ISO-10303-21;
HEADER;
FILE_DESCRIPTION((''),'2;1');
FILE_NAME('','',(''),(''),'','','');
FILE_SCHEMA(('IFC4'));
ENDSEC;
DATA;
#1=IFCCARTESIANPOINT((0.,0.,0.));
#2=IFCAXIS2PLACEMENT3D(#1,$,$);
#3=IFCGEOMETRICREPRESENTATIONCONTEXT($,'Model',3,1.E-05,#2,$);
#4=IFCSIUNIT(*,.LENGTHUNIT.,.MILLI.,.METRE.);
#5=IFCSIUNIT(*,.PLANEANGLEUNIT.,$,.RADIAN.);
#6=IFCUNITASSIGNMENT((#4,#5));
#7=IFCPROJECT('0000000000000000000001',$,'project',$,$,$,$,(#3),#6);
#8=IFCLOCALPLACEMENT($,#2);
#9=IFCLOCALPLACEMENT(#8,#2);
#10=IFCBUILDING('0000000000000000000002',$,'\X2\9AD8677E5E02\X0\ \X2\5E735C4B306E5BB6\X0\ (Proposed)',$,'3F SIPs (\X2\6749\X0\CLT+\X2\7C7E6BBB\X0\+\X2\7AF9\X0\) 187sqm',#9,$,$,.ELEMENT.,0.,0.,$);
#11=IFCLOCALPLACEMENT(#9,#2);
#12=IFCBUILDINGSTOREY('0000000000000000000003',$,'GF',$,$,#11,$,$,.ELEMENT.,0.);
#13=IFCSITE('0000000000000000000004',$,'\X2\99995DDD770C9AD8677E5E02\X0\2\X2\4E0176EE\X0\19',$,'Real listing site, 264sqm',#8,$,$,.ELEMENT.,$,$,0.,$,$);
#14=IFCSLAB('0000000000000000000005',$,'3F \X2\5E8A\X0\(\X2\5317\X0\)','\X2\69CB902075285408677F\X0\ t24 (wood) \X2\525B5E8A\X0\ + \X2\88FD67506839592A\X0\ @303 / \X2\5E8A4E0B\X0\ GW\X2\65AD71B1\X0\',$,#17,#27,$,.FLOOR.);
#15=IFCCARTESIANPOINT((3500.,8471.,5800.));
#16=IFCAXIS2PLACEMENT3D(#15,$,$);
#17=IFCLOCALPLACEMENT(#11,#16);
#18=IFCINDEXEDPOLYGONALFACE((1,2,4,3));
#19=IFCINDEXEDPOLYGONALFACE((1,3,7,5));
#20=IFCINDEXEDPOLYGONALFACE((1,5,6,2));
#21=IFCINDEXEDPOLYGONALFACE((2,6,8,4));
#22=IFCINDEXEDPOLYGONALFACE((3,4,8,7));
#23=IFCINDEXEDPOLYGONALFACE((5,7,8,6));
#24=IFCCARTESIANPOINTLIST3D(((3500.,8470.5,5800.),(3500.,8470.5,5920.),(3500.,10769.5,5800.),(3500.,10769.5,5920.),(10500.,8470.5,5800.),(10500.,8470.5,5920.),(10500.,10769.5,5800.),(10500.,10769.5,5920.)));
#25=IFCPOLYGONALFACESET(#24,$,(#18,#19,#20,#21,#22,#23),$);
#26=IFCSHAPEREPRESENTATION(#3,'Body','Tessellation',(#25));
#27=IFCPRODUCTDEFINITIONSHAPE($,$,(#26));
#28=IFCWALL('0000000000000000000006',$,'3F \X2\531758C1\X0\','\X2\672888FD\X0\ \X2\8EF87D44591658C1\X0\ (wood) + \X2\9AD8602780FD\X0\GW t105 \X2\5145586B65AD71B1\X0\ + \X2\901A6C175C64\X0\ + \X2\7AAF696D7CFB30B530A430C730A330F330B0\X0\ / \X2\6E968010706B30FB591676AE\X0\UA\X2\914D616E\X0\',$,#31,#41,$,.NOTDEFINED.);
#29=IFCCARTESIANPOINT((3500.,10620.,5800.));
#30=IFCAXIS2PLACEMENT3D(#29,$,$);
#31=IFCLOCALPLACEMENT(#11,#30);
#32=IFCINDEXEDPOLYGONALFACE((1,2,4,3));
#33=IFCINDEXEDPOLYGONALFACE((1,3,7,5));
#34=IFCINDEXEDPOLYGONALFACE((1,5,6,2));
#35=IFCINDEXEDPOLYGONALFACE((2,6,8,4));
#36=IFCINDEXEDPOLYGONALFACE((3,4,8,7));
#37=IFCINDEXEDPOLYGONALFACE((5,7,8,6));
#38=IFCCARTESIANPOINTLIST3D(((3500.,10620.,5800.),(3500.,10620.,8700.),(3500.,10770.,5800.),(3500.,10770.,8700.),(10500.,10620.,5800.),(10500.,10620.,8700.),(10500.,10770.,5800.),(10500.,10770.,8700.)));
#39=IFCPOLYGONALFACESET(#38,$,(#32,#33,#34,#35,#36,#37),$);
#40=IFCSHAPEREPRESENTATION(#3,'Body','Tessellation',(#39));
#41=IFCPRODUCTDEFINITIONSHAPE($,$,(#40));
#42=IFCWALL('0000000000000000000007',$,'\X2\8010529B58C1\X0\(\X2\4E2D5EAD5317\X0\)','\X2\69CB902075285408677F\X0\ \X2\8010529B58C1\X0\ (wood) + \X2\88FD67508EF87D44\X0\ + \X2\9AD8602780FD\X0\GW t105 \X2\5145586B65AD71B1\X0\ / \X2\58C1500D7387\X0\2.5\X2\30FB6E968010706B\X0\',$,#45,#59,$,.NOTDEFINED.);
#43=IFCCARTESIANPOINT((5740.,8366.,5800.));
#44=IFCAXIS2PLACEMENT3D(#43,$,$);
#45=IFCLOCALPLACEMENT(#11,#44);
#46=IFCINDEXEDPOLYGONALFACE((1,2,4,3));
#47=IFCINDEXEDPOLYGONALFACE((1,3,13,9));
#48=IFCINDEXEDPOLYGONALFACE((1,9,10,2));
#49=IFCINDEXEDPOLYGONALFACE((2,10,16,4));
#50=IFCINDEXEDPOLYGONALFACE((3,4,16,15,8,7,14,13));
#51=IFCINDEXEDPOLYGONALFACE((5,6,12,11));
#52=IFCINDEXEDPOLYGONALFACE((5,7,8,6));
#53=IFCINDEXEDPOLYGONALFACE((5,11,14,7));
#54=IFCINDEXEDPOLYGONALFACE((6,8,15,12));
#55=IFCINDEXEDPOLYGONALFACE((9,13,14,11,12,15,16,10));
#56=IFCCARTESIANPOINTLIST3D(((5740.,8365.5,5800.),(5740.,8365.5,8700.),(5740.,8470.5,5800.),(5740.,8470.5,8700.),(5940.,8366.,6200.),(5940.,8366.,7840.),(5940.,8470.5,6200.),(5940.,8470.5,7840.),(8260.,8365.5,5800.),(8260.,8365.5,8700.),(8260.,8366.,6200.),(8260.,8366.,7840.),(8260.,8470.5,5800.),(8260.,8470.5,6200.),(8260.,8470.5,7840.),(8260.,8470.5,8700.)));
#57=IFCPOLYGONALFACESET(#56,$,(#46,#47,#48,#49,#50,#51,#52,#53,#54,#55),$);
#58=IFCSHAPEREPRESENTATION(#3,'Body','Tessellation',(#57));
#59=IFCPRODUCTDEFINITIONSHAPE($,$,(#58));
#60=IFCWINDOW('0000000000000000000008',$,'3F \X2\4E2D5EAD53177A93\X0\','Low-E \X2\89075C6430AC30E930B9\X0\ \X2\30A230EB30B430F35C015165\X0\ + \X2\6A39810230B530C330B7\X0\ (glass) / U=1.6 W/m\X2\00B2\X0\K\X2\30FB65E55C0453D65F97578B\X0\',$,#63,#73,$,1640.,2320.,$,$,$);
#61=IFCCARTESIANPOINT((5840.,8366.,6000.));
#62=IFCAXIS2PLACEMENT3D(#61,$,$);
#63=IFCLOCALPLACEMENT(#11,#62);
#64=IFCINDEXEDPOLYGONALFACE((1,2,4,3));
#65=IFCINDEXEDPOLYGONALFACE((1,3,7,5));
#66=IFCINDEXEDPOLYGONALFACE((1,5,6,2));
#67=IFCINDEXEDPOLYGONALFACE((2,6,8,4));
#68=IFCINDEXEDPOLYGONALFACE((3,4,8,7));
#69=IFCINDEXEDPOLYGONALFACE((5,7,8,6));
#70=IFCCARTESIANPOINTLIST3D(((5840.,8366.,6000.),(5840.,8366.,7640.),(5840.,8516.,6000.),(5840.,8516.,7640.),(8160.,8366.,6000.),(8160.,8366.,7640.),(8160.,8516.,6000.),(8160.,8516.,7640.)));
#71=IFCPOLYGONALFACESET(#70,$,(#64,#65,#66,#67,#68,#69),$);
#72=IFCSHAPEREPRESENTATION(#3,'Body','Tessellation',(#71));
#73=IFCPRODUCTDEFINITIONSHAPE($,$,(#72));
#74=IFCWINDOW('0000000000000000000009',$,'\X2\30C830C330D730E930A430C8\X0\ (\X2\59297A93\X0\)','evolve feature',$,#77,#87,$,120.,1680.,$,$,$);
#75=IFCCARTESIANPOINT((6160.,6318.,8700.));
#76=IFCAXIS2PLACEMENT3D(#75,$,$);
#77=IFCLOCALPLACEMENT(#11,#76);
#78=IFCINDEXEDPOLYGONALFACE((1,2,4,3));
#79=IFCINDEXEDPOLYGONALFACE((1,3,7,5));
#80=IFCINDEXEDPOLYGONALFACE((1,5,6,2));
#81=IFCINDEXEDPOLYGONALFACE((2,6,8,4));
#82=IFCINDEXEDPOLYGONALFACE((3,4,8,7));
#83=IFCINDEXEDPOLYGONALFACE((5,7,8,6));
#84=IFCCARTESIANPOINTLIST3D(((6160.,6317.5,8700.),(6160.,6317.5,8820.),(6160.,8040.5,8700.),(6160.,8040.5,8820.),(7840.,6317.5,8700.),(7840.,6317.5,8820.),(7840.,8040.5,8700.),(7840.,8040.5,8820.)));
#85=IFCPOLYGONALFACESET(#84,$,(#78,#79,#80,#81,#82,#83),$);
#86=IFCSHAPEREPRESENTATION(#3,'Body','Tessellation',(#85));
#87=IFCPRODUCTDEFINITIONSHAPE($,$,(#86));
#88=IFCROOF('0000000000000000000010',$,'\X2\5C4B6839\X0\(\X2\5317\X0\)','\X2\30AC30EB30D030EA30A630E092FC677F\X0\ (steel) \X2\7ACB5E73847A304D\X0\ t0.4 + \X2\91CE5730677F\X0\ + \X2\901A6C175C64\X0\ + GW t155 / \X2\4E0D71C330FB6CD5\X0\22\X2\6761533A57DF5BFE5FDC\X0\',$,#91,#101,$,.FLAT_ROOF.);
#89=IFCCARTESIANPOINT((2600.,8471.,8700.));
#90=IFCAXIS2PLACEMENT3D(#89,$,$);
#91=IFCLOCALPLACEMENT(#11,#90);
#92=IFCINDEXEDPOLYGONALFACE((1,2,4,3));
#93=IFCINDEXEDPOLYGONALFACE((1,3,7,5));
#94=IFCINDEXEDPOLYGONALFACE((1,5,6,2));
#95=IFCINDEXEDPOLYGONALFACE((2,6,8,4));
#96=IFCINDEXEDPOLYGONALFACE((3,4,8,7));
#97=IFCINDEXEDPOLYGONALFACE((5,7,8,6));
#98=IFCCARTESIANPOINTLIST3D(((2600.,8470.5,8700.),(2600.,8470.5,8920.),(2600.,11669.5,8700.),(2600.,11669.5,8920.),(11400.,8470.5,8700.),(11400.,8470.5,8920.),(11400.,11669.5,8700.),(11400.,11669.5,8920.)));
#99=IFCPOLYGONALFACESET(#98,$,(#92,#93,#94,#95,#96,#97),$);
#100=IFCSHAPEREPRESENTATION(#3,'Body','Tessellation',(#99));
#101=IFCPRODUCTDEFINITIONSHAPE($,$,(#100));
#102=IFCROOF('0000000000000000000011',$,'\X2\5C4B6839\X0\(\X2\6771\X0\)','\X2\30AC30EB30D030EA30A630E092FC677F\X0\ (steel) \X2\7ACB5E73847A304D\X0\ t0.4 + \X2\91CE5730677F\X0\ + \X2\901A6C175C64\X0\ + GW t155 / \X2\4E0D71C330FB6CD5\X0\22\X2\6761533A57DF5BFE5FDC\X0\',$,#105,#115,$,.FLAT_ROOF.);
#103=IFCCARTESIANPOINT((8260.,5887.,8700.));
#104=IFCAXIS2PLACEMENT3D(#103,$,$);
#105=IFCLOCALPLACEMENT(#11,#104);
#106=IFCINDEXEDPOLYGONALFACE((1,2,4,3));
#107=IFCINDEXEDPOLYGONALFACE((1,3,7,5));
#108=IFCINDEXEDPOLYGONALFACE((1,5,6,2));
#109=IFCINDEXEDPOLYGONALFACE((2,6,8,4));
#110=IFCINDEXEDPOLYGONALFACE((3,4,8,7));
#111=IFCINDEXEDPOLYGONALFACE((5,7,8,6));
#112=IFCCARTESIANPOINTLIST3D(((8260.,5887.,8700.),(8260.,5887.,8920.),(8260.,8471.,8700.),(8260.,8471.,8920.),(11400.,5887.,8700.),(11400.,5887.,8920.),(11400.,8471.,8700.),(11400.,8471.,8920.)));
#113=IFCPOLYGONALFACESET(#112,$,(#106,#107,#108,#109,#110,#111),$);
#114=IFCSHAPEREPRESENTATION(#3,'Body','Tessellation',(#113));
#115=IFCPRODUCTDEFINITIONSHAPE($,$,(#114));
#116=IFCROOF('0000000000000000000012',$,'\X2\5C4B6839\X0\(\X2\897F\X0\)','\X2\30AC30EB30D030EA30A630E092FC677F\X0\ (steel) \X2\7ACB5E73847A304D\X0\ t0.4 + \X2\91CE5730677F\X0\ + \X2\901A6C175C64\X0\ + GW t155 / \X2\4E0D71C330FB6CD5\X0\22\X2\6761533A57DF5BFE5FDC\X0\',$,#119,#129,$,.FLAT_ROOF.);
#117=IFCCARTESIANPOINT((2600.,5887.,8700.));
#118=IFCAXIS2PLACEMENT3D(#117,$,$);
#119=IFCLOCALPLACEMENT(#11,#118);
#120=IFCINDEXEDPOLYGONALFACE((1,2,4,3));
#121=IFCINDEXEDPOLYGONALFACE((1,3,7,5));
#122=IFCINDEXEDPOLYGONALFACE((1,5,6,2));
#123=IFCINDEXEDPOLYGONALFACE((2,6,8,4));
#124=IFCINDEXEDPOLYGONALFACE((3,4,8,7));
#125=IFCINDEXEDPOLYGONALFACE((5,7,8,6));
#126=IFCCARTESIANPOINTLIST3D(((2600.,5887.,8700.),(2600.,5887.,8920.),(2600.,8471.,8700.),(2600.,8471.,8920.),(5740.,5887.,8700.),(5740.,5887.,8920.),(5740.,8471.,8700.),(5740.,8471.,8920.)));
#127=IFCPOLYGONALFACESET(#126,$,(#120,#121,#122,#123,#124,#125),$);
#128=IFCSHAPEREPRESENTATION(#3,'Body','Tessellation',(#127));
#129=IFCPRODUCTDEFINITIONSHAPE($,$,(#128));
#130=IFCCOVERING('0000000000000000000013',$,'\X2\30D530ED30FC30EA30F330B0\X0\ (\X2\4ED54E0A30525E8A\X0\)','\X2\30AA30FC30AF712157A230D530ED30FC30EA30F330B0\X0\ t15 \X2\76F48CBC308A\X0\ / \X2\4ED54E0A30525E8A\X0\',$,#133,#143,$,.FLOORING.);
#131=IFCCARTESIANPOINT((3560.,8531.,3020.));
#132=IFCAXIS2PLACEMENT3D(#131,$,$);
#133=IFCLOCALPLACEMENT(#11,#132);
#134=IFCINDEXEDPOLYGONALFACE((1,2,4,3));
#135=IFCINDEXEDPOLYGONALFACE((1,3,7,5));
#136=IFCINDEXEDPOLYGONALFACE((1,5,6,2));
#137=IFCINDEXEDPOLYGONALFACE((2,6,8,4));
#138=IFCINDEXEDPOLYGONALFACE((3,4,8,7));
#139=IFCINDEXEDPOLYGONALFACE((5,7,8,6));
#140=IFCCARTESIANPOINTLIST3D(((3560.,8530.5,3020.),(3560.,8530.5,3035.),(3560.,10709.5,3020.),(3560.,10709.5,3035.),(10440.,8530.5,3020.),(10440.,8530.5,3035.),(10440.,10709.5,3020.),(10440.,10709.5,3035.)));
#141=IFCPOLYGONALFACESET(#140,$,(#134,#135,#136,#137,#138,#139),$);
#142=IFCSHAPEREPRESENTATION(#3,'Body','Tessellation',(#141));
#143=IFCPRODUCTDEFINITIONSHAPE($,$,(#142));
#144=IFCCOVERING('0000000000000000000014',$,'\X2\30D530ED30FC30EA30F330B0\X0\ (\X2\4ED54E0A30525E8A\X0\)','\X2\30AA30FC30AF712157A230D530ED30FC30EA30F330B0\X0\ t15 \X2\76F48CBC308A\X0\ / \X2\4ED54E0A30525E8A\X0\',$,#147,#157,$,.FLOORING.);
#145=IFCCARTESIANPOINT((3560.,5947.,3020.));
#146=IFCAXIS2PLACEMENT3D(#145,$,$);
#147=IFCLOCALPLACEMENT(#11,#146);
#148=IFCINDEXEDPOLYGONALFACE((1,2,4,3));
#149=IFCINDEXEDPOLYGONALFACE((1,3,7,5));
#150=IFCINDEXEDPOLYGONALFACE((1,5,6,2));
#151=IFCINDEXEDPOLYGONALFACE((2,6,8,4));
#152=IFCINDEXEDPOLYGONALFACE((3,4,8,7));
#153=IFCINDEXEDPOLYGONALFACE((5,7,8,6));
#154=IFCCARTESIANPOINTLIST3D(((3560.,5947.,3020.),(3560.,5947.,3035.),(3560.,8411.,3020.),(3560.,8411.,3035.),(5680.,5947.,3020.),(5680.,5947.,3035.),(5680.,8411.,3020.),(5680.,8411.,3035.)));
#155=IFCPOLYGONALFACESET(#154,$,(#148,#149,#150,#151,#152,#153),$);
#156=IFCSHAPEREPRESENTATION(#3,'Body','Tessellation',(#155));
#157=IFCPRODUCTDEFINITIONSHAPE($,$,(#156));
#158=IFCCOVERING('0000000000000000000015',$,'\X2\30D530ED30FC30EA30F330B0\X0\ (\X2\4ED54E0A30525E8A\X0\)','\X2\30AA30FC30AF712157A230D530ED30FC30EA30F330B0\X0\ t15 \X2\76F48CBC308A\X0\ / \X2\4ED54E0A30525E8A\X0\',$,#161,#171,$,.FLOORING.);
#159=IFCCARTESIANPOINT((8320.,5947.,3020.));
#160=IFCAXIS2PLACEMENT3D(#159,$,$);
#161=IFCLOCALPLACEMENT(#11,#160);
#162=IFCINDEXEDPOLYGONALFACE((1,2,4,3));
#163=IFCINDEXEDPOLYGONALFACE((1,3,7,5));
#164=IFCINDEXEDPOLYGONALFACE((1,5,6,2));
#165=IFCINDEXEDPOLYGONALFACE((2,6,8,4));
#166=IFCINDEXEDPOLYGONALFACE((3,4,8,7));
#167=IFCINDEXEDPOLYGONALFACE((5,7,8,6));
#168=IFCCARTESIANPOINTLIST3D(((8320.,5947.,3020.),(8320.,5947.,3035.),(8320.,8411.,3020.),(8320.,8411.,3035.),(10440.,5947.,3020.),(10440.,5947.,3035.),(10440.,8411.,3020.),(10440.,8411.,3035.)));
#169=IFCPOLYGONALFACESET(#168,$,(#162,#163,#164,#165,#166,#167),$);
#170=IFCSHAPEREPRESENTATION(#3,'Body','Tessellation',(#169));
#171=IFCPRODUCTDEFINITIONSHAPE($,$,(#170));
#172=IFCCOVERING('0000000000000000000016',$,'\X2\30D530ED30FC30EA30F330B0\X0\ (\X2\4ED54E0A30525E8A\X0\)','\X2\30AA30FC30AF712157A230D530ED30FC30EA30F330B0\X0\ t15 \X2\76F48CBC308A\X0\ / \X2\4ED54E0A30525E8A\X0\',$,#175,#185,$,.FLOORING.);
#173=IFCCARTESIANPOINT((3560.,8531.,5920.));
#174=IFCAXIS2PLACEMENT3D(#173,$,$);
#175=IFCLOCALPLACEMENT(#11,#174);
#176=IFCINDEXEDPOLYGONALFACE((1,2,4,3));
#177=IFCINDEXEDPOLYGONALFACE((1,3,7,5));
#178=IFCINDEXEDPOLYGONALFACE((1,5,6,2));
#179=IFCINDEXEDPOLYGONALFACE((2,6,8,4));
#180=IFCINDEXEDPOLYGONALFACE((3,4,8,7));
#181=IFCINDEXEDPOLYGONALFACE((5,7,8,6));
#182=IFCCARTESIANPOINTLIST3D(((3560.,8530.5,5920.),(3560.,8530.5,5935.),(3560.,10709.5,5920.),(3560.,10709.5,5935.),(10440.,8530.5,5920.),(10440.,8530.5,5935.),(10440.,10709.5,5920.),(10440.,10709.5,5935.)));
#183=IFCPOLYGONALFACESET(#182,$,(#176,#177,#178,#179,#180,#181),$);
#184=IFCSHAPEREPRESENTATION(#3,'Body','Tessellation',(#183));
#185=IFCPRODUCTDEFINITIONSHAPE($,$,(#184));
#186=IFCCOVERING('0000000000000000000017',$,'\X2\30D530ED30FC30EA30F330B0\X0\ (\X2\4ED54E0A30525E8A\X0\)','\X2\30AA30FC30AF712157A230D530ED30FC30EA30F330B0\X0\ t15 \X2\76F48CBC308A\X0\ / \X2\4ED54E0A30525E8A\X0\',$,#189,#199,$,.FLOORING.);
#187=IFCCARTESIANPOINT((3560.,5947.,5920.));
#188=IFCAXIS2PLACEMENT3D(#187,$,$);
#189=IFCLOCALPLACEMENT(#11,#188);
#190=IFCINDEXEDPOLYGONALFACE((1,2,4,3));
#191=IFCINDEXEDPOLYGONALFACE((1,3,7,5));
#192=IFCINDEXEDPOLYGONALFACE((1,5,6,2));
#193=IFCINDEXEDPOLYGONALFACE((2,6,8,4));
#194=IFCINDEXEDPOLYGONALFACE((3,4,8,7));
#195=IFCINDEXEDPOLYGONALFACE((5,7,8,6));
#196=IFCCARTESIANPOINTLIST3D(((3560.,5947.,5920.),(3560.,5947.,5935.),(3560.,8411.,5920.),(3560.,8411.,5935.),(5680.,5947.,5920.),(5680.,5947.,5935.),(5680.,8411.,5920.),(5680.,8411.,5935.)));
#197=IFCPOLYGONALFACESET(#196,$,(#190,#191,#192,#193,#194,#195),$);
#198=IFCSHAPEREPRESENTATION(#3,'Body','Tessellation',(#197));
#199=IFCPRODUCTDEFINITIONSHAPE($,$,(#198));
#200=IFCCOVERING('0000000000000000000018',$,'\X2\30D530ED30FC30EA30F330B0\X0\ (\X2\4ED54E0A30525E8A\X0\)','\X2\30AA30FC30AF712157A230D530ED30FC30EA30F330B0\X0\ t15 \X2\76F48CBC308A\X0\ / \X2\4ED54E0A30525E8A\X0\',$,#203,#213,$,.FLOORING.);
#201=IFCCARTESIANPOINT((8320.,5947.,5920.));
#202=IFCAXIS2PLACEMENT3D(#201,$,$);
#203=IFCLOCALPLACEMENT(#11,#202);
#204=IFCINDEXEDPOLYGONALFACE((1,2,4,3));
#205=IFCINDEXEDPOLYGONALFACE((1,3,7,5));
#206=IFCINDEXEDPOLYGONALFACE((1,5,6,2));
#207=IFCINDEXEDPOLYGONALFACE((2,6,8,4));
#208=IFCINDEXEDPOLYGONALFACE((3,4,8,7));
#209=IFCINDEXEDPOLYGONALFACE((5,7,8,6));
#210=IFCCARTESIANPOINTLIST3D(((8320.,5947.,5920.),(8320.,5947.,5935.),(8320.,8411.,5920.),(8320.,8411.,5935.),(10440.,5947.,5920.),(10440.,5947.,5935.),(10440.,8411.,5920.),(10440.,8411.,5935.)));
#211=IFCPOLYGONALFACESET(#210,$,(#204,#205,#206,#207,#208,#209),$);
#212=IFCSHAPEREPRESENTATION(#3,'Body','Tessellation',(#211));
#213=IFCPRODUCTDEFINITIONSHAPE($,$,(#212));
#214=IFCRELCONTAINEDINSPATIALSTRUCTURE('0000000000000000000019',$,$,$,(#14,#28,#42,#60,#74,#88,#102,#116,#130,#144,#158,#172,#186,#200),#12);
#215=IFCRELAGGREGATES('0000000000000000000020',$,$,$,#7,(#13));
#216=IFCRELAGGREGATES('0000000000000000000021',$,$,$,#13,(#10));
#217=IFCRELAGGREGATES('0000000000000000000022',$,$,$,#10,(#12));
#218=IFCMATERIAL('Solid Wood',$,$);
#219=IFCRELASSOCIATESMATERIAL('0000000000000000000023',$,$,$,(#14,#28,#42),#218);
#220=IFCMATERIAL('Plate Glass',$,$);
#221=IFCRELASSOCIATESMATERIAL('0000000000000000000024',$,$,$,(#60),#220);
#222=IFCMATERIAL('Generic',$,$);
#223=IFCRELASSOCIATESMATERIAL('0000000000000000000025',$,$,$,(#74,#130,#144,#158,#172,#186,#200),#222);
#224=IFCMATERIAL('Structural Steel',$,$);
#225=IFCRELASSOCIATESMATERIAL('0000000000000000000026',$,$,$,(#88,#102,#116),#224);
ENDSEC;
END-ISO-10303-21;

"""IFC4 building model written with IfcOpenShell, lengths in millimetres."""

from ifc_helpers import new_model, si_unit, frame, frame_2d, origin, place, context, project, spatial, rectangle, extrude, material, element, fill, save


model = new_model("IFC4")

# Units and contexts
model_context = context("Model", 3, precision=1e-05, world=origin())
ifc_project = project(units=[si_unit("LENGTHUNIT", "METRE", prefix="MILLI"), si_unit("PLANEANGLEUNIT", "RADIAN")], contexts=[model_context])

# Site, building, storey
site_placement = place(None, origin())
site = spatial("IfcSite", under=ifc_project, at=site_placement, Name="香川県高松市2丁目19", ObjectType="Real listing site, 264sqm", CompositionType="ELEMENT", RefElevation=0.0)
building_placement = place(site_placement, origin())
building = spatial("IfcBuilding", under=site, at=building_placement, Name="高松市 平屋の家 (Proposed)", ObjectType="3F SIPs (杉CLT+籾殻+竹) 187sqm", CompositionType="ELEMENT", ElevationOfRefHeight=0.0, ElevationOfTerrain=0.0)
storey_placement = place(building_placement, origin())
storey = spatial("IfcBuildingStorey", under=building, at=storey_placement, Name="GF", CompositionType="ELEMENT", Elevation=0.0)

# Slab
ifc_material_1 = material(Name="Solid Wood")
slab_placement = place(storey_placement, frame((3500.0, 8471.0, 5800.0)))
element("IfcSlab", 1, at=slab_placement, inside=storey, material=ifc_material_1, Name="3F 床(北)", Description="構造用合板 t24 (wood) 剛床 + 製材根太 @303 / 床下 GW断熱", PredefinedType="FLOOR", context=model_context, shape_type="SweptSolid", body=[
    extrude(rectangle(XDim=7000.0, YDim=2299.0, at=frame_2d((3500.0, 1149.0))), frame((3500.0, 8471.0, 5800.0)), (0.0, 0.0, 1.0), 120.0),
])

# Wall
wall_1_placement = place(storey_placement, frame((3500.0, 10620.0, 5800.0)))
element("IfcWall", 2, at=wall_1_placement, inside=storey, material=ifc_material_1, Name="3F 北壁", Description="木製 軸組外壁 (wood) + 高性能GW t105 充填断熱 + 通気層 + 窯業系サイディング / 準耐火・外皮UA配慮", PredefinedType="NOTDEFINED", context=model_context, shape_type="SweptSolid", body=[
    extrude(rectangle(XDim=7000.0, YDim=150.0, at=frame_2d((3500.0, 75.0))), frame((3500.0, 10620.0, 5800.0)), (0.0, 0.0, 1.0), 2900.0),
])

# Wall, opening, window
wall_2_placement = place(storey_placement, frame((5740.0, 8366.0, 5800.0)))
wall_2 = element("IfcWall", 3, at=wall_2_placement, inside=storey, material=ifc_material_1, Name="耐力壁(中庭北)", Description="構造用合板 耐力壁 (wood) + 製材軸組 + 高性能GW t105 充填断熱 / 壁倍率2.5・準耐火", PredefinedType="NOTDEFINED", context=model_context, shape_type="SweptSolid", body=[
    extrude(rectangle(XDim=2520.0, YDim=105.0, at=frame_2d((1260.0, 52.0))), frame((5740.0, 8366.0, 5800.0)), (0.0, 0.0, 1.0), 2900.0),
])
opening_placement = place(storey_placement, frame((5840.0, 8366.0, 6000.0)))
opening = element("IfcOpeningElement", 4, at=opening_placement, cuts=wall_2, PredefinedType="NOTDEFINED", context=model_context, shape_type="SweptSolid", body=[
    extrude(rectangle(XDim=2320.0, YDim=150.0, at=frame_2d((1160.0, 75.0))), frame((5840.0, 8366.0, 6000.0)), (0.0, 0.0, 1.0), 1640.0),
])
ifc_material_2 = material(Name="Plate Glass")
window_1_placement = place(storey_placement, frame((5840.0, 8366.0, 6000.0)))
window_1 = element("IfcWindow", 5, at=window_1_placement, inside=storey, material=ifc_material_2, Name="3F 中庭北窓", Description="Low-E 複層ガラス アルゴン封入 + 樹脂サッシ (glass) / U=1.6 W/m²K・日射取得型", OverallHeight=1640.0, OverallWidth=2320.0, context=model_context, shape_type="SweptSolid", body=[
    extrude(rectangle(XDim=2320.0, YDim=150.0, at=frame_2d((1160.0, 75.0))), frame((5840.0, 8366.0, 6000.0)), (0.0, 0.0, 1.0), 1640.0),
])
fill(opening, window_1)

# Window
ifc_material_3 = material(Name="Generic")
window_2_placement = place(storey_placement, frame((6160.0, 6318.0, 8700.0)))
element("IfcWindow", 6, at=window_2_placement, inside=storey, material=ifc_material_3, Name="トップライト (天窓)", Description="evolve feature", OverallHeight=120.0, OverallWidth=1680.0, context=model_context, shape_type="SweptSolid", body=[
    extrude(rectangle(XDim=1680.0, YDim=1723.0, at=frame_2d((840.0, 861.0))), frame((6160.0, 6318.0, 8700.0)), (0.0, 0.0, 1.0), 120.0),
])

# Roofs
ifc_material_4 = material(Name="Structural Steel")
roof_1_placement = place(storey_placement, frame((2600.0, 8471.0, 8700.0)))
element("IfcRoof", 7, at=roof_1_placement, inside=storey, material=ifc_material_4, Name="屋根(北)", Description="ガルバリウム鋼板 (steel) 立平葺き t0.4 + 野地板 + 通気層 + GW t155 / 不燃・法22条区域対応", PredefinedType="FLAT_ROOF", context=model_context, shape_type="SweptSolid", body=[
    extrude(rectangle(XDim=8800.0, YDim=3199.0, at=frame_2d((4400.0, 1599.0))), frame((2600.0, 8471.0, 8700.0)), (0.0, 0.0, 1.0), 220.0),
])
roof_2_placement = place(storey_placement, frame((8260.0, 5887.0, 8700.0)))
element("IfcRoof", 8, at=roof_2_placement, inside=storey, material=ifc_material_4, Name="屋根(東)", Description="ガルバリウム鋼板 (steel) 立平葺き t0.4 + 野地板 + 通気層 + GW t155 / 不燃・法22条区域対応", PredefinedType="FLAT_ROOF", context=model_context, shape_type="SweptSolid", body=[
    extrude(rectangle(XDim=3140.0, YDim=2584.0, at=frame_2d((1570.0, 1292.0))), frame((8260.0, 5887.0, 8700.0)), (0.0, 0.0, 1.0), 220.0),
])
roof_3_placement = place(storey_placement, frame((2600.0, 5887.0, 8700.0)))
element("IfcRoof", 9, at=roof_3_placement, inside=storey, material=ifc_material_4, Name="屋根(西)", Description="ガルバリウム鋼板 (steel) 立平葺き t0.4 + 野地板 + 通気層 + GW t155 / 不燃・法22条区域対応", PredefinedType="FLAT_ROOF", context=model_context, shape_type="SweptSolid", body=[
    extrude(rectangle(XDim=3140.0, YDim=2584.0, at=frame_2d((1570.0, 1292.0))), frame((2600.0, 5887.0, 8700.0)), (0.0, 0.0, 1.0), 220.0),
])

# Coverings
covering_1_placement = place(storey_placement, frame((3560.0, 8531.0, 3020.0)))
element("IfcCovering", 10, at=covering_1_placement, inside=storey, material=ifc_material_3, Name="フローリング (仕上げ床)", Description="オーク無垢フローリング t15 直貼り / 仕上げ床", PredefinedType="FLOORING", context=model_context, shape_type="SweptSolid", body=[
    extrude(rectangle(XDim=6880.0, YDim=2179.0, at=frame_2d((3440.0, 1089.0))), frame((3560.0, 8531.0, 3020.0)), (0.0, 0.0, 1.0), 15.0),
])
covering_2_placement = place(storey_placement, frame((3560.0, 5947.0, 3020.0)))
element("IfcCovering", 11, at=covering_2_placement, inside=storey, material=ifc_material_3, Name="フローリング (仕上げ床)", Description="オーク無垢フローリング t15 直貼り / 仕上げ床", PredefinedType="FLOORING", context=model_context, shape_type="SweptSolid", body=[
    extrude(rectangle(XDim=2120.0, YDim=2464.0, at=frame_2d((1060.0, 1232.0))), frame((3560.0, 5947.0, 3020.0)), (0.0, 0.0, 1.0), 15.0),
])
covering_3_placement = place(storey_placement, frame((8320.0, 5947.0, 3020.0)))
element("IfcCovering", 12, at=covering_3_placement, inside=storey, material=ifc_material_3, Name="フローリング (仕上げ床)", Description="オーク無垢フローリング t15 直貼り / 仕上げ床", PredefinedType="FLOORING", context=model_context, shape_type="SweptSolid", body=[
    extrude(rectangle(XDim=2120.0, YDim=2464.0, at=frame_2d((1060.0, 1232.0))), frame((8320.0, 5947.0, 3020.0)), (0.0, 0.0, 1.0), 15.0),
])
covering_4_placement = place(storey_placement, frame((3560.0, 8531.0, 5920.0)))
element("IfcCovering", 13, at=covering_4_placement, inside=storey, material=ifc_material_3, Name="フローリング (仕上げ床)", Description="オーク無垢フローリング t15 直貼り / 仕上げ床", PredefinedType="FLOORING", context=model_context, shape_type="SweptSolid", body=[
    extrude(rectangle(XDim=6880.0, YDim=2179.0, at=frame_2d((3440.0, 1089.0))), frame((3560.0, 8531.0, 5920.0)), (0.0, 0.0, 1.0), 15.0),
])
covering_5_placement = place(storey_placement, frame((3560.0, 5947.0, 5920.0)))
element("IfcCovering", 14, at=covering_5_placement, inside=storey, material=ifc_material_3, Name="フローリング (仕上げ床)", Description="オーク無垢フローリング t15 直貼り / 仕上げ床", PredefinedType="FLOORING", context=model_context, shape_type="SweptSolid", body=[
    extrude(rectangle(XDim=2120.0, YDim=2464.0, at=frame_2d((1060.0, 1232.0))), frame((3560.0, 5947.0, 5920.0)), (0.0, 0.0, 1.0), 15.0),
])
covering_6_placement = place(storey_placement, frame((8320.0, 5947.0, 5920.0)))
element("IfcCovering", 15, at=covering_6_placement, inside=storey, material=ifc_material_3, Name="フローリング (仕上げ床)", Description="オーク無垢フローリング t15 直貼り / 仕上げ床", PredefinedType="FLOORING", context=model_context, shape_type="SweptSolid", body=[
    extrude(rectangle(XDim=2120.0, YDim=2464.0, at=frame_2d((1060.0, 1232.0))), frame((8320.0, 5947.0, 5920.0)), (0.0, 0.0, 1.0), 15.0),
])

save(model, "model.ifc")
